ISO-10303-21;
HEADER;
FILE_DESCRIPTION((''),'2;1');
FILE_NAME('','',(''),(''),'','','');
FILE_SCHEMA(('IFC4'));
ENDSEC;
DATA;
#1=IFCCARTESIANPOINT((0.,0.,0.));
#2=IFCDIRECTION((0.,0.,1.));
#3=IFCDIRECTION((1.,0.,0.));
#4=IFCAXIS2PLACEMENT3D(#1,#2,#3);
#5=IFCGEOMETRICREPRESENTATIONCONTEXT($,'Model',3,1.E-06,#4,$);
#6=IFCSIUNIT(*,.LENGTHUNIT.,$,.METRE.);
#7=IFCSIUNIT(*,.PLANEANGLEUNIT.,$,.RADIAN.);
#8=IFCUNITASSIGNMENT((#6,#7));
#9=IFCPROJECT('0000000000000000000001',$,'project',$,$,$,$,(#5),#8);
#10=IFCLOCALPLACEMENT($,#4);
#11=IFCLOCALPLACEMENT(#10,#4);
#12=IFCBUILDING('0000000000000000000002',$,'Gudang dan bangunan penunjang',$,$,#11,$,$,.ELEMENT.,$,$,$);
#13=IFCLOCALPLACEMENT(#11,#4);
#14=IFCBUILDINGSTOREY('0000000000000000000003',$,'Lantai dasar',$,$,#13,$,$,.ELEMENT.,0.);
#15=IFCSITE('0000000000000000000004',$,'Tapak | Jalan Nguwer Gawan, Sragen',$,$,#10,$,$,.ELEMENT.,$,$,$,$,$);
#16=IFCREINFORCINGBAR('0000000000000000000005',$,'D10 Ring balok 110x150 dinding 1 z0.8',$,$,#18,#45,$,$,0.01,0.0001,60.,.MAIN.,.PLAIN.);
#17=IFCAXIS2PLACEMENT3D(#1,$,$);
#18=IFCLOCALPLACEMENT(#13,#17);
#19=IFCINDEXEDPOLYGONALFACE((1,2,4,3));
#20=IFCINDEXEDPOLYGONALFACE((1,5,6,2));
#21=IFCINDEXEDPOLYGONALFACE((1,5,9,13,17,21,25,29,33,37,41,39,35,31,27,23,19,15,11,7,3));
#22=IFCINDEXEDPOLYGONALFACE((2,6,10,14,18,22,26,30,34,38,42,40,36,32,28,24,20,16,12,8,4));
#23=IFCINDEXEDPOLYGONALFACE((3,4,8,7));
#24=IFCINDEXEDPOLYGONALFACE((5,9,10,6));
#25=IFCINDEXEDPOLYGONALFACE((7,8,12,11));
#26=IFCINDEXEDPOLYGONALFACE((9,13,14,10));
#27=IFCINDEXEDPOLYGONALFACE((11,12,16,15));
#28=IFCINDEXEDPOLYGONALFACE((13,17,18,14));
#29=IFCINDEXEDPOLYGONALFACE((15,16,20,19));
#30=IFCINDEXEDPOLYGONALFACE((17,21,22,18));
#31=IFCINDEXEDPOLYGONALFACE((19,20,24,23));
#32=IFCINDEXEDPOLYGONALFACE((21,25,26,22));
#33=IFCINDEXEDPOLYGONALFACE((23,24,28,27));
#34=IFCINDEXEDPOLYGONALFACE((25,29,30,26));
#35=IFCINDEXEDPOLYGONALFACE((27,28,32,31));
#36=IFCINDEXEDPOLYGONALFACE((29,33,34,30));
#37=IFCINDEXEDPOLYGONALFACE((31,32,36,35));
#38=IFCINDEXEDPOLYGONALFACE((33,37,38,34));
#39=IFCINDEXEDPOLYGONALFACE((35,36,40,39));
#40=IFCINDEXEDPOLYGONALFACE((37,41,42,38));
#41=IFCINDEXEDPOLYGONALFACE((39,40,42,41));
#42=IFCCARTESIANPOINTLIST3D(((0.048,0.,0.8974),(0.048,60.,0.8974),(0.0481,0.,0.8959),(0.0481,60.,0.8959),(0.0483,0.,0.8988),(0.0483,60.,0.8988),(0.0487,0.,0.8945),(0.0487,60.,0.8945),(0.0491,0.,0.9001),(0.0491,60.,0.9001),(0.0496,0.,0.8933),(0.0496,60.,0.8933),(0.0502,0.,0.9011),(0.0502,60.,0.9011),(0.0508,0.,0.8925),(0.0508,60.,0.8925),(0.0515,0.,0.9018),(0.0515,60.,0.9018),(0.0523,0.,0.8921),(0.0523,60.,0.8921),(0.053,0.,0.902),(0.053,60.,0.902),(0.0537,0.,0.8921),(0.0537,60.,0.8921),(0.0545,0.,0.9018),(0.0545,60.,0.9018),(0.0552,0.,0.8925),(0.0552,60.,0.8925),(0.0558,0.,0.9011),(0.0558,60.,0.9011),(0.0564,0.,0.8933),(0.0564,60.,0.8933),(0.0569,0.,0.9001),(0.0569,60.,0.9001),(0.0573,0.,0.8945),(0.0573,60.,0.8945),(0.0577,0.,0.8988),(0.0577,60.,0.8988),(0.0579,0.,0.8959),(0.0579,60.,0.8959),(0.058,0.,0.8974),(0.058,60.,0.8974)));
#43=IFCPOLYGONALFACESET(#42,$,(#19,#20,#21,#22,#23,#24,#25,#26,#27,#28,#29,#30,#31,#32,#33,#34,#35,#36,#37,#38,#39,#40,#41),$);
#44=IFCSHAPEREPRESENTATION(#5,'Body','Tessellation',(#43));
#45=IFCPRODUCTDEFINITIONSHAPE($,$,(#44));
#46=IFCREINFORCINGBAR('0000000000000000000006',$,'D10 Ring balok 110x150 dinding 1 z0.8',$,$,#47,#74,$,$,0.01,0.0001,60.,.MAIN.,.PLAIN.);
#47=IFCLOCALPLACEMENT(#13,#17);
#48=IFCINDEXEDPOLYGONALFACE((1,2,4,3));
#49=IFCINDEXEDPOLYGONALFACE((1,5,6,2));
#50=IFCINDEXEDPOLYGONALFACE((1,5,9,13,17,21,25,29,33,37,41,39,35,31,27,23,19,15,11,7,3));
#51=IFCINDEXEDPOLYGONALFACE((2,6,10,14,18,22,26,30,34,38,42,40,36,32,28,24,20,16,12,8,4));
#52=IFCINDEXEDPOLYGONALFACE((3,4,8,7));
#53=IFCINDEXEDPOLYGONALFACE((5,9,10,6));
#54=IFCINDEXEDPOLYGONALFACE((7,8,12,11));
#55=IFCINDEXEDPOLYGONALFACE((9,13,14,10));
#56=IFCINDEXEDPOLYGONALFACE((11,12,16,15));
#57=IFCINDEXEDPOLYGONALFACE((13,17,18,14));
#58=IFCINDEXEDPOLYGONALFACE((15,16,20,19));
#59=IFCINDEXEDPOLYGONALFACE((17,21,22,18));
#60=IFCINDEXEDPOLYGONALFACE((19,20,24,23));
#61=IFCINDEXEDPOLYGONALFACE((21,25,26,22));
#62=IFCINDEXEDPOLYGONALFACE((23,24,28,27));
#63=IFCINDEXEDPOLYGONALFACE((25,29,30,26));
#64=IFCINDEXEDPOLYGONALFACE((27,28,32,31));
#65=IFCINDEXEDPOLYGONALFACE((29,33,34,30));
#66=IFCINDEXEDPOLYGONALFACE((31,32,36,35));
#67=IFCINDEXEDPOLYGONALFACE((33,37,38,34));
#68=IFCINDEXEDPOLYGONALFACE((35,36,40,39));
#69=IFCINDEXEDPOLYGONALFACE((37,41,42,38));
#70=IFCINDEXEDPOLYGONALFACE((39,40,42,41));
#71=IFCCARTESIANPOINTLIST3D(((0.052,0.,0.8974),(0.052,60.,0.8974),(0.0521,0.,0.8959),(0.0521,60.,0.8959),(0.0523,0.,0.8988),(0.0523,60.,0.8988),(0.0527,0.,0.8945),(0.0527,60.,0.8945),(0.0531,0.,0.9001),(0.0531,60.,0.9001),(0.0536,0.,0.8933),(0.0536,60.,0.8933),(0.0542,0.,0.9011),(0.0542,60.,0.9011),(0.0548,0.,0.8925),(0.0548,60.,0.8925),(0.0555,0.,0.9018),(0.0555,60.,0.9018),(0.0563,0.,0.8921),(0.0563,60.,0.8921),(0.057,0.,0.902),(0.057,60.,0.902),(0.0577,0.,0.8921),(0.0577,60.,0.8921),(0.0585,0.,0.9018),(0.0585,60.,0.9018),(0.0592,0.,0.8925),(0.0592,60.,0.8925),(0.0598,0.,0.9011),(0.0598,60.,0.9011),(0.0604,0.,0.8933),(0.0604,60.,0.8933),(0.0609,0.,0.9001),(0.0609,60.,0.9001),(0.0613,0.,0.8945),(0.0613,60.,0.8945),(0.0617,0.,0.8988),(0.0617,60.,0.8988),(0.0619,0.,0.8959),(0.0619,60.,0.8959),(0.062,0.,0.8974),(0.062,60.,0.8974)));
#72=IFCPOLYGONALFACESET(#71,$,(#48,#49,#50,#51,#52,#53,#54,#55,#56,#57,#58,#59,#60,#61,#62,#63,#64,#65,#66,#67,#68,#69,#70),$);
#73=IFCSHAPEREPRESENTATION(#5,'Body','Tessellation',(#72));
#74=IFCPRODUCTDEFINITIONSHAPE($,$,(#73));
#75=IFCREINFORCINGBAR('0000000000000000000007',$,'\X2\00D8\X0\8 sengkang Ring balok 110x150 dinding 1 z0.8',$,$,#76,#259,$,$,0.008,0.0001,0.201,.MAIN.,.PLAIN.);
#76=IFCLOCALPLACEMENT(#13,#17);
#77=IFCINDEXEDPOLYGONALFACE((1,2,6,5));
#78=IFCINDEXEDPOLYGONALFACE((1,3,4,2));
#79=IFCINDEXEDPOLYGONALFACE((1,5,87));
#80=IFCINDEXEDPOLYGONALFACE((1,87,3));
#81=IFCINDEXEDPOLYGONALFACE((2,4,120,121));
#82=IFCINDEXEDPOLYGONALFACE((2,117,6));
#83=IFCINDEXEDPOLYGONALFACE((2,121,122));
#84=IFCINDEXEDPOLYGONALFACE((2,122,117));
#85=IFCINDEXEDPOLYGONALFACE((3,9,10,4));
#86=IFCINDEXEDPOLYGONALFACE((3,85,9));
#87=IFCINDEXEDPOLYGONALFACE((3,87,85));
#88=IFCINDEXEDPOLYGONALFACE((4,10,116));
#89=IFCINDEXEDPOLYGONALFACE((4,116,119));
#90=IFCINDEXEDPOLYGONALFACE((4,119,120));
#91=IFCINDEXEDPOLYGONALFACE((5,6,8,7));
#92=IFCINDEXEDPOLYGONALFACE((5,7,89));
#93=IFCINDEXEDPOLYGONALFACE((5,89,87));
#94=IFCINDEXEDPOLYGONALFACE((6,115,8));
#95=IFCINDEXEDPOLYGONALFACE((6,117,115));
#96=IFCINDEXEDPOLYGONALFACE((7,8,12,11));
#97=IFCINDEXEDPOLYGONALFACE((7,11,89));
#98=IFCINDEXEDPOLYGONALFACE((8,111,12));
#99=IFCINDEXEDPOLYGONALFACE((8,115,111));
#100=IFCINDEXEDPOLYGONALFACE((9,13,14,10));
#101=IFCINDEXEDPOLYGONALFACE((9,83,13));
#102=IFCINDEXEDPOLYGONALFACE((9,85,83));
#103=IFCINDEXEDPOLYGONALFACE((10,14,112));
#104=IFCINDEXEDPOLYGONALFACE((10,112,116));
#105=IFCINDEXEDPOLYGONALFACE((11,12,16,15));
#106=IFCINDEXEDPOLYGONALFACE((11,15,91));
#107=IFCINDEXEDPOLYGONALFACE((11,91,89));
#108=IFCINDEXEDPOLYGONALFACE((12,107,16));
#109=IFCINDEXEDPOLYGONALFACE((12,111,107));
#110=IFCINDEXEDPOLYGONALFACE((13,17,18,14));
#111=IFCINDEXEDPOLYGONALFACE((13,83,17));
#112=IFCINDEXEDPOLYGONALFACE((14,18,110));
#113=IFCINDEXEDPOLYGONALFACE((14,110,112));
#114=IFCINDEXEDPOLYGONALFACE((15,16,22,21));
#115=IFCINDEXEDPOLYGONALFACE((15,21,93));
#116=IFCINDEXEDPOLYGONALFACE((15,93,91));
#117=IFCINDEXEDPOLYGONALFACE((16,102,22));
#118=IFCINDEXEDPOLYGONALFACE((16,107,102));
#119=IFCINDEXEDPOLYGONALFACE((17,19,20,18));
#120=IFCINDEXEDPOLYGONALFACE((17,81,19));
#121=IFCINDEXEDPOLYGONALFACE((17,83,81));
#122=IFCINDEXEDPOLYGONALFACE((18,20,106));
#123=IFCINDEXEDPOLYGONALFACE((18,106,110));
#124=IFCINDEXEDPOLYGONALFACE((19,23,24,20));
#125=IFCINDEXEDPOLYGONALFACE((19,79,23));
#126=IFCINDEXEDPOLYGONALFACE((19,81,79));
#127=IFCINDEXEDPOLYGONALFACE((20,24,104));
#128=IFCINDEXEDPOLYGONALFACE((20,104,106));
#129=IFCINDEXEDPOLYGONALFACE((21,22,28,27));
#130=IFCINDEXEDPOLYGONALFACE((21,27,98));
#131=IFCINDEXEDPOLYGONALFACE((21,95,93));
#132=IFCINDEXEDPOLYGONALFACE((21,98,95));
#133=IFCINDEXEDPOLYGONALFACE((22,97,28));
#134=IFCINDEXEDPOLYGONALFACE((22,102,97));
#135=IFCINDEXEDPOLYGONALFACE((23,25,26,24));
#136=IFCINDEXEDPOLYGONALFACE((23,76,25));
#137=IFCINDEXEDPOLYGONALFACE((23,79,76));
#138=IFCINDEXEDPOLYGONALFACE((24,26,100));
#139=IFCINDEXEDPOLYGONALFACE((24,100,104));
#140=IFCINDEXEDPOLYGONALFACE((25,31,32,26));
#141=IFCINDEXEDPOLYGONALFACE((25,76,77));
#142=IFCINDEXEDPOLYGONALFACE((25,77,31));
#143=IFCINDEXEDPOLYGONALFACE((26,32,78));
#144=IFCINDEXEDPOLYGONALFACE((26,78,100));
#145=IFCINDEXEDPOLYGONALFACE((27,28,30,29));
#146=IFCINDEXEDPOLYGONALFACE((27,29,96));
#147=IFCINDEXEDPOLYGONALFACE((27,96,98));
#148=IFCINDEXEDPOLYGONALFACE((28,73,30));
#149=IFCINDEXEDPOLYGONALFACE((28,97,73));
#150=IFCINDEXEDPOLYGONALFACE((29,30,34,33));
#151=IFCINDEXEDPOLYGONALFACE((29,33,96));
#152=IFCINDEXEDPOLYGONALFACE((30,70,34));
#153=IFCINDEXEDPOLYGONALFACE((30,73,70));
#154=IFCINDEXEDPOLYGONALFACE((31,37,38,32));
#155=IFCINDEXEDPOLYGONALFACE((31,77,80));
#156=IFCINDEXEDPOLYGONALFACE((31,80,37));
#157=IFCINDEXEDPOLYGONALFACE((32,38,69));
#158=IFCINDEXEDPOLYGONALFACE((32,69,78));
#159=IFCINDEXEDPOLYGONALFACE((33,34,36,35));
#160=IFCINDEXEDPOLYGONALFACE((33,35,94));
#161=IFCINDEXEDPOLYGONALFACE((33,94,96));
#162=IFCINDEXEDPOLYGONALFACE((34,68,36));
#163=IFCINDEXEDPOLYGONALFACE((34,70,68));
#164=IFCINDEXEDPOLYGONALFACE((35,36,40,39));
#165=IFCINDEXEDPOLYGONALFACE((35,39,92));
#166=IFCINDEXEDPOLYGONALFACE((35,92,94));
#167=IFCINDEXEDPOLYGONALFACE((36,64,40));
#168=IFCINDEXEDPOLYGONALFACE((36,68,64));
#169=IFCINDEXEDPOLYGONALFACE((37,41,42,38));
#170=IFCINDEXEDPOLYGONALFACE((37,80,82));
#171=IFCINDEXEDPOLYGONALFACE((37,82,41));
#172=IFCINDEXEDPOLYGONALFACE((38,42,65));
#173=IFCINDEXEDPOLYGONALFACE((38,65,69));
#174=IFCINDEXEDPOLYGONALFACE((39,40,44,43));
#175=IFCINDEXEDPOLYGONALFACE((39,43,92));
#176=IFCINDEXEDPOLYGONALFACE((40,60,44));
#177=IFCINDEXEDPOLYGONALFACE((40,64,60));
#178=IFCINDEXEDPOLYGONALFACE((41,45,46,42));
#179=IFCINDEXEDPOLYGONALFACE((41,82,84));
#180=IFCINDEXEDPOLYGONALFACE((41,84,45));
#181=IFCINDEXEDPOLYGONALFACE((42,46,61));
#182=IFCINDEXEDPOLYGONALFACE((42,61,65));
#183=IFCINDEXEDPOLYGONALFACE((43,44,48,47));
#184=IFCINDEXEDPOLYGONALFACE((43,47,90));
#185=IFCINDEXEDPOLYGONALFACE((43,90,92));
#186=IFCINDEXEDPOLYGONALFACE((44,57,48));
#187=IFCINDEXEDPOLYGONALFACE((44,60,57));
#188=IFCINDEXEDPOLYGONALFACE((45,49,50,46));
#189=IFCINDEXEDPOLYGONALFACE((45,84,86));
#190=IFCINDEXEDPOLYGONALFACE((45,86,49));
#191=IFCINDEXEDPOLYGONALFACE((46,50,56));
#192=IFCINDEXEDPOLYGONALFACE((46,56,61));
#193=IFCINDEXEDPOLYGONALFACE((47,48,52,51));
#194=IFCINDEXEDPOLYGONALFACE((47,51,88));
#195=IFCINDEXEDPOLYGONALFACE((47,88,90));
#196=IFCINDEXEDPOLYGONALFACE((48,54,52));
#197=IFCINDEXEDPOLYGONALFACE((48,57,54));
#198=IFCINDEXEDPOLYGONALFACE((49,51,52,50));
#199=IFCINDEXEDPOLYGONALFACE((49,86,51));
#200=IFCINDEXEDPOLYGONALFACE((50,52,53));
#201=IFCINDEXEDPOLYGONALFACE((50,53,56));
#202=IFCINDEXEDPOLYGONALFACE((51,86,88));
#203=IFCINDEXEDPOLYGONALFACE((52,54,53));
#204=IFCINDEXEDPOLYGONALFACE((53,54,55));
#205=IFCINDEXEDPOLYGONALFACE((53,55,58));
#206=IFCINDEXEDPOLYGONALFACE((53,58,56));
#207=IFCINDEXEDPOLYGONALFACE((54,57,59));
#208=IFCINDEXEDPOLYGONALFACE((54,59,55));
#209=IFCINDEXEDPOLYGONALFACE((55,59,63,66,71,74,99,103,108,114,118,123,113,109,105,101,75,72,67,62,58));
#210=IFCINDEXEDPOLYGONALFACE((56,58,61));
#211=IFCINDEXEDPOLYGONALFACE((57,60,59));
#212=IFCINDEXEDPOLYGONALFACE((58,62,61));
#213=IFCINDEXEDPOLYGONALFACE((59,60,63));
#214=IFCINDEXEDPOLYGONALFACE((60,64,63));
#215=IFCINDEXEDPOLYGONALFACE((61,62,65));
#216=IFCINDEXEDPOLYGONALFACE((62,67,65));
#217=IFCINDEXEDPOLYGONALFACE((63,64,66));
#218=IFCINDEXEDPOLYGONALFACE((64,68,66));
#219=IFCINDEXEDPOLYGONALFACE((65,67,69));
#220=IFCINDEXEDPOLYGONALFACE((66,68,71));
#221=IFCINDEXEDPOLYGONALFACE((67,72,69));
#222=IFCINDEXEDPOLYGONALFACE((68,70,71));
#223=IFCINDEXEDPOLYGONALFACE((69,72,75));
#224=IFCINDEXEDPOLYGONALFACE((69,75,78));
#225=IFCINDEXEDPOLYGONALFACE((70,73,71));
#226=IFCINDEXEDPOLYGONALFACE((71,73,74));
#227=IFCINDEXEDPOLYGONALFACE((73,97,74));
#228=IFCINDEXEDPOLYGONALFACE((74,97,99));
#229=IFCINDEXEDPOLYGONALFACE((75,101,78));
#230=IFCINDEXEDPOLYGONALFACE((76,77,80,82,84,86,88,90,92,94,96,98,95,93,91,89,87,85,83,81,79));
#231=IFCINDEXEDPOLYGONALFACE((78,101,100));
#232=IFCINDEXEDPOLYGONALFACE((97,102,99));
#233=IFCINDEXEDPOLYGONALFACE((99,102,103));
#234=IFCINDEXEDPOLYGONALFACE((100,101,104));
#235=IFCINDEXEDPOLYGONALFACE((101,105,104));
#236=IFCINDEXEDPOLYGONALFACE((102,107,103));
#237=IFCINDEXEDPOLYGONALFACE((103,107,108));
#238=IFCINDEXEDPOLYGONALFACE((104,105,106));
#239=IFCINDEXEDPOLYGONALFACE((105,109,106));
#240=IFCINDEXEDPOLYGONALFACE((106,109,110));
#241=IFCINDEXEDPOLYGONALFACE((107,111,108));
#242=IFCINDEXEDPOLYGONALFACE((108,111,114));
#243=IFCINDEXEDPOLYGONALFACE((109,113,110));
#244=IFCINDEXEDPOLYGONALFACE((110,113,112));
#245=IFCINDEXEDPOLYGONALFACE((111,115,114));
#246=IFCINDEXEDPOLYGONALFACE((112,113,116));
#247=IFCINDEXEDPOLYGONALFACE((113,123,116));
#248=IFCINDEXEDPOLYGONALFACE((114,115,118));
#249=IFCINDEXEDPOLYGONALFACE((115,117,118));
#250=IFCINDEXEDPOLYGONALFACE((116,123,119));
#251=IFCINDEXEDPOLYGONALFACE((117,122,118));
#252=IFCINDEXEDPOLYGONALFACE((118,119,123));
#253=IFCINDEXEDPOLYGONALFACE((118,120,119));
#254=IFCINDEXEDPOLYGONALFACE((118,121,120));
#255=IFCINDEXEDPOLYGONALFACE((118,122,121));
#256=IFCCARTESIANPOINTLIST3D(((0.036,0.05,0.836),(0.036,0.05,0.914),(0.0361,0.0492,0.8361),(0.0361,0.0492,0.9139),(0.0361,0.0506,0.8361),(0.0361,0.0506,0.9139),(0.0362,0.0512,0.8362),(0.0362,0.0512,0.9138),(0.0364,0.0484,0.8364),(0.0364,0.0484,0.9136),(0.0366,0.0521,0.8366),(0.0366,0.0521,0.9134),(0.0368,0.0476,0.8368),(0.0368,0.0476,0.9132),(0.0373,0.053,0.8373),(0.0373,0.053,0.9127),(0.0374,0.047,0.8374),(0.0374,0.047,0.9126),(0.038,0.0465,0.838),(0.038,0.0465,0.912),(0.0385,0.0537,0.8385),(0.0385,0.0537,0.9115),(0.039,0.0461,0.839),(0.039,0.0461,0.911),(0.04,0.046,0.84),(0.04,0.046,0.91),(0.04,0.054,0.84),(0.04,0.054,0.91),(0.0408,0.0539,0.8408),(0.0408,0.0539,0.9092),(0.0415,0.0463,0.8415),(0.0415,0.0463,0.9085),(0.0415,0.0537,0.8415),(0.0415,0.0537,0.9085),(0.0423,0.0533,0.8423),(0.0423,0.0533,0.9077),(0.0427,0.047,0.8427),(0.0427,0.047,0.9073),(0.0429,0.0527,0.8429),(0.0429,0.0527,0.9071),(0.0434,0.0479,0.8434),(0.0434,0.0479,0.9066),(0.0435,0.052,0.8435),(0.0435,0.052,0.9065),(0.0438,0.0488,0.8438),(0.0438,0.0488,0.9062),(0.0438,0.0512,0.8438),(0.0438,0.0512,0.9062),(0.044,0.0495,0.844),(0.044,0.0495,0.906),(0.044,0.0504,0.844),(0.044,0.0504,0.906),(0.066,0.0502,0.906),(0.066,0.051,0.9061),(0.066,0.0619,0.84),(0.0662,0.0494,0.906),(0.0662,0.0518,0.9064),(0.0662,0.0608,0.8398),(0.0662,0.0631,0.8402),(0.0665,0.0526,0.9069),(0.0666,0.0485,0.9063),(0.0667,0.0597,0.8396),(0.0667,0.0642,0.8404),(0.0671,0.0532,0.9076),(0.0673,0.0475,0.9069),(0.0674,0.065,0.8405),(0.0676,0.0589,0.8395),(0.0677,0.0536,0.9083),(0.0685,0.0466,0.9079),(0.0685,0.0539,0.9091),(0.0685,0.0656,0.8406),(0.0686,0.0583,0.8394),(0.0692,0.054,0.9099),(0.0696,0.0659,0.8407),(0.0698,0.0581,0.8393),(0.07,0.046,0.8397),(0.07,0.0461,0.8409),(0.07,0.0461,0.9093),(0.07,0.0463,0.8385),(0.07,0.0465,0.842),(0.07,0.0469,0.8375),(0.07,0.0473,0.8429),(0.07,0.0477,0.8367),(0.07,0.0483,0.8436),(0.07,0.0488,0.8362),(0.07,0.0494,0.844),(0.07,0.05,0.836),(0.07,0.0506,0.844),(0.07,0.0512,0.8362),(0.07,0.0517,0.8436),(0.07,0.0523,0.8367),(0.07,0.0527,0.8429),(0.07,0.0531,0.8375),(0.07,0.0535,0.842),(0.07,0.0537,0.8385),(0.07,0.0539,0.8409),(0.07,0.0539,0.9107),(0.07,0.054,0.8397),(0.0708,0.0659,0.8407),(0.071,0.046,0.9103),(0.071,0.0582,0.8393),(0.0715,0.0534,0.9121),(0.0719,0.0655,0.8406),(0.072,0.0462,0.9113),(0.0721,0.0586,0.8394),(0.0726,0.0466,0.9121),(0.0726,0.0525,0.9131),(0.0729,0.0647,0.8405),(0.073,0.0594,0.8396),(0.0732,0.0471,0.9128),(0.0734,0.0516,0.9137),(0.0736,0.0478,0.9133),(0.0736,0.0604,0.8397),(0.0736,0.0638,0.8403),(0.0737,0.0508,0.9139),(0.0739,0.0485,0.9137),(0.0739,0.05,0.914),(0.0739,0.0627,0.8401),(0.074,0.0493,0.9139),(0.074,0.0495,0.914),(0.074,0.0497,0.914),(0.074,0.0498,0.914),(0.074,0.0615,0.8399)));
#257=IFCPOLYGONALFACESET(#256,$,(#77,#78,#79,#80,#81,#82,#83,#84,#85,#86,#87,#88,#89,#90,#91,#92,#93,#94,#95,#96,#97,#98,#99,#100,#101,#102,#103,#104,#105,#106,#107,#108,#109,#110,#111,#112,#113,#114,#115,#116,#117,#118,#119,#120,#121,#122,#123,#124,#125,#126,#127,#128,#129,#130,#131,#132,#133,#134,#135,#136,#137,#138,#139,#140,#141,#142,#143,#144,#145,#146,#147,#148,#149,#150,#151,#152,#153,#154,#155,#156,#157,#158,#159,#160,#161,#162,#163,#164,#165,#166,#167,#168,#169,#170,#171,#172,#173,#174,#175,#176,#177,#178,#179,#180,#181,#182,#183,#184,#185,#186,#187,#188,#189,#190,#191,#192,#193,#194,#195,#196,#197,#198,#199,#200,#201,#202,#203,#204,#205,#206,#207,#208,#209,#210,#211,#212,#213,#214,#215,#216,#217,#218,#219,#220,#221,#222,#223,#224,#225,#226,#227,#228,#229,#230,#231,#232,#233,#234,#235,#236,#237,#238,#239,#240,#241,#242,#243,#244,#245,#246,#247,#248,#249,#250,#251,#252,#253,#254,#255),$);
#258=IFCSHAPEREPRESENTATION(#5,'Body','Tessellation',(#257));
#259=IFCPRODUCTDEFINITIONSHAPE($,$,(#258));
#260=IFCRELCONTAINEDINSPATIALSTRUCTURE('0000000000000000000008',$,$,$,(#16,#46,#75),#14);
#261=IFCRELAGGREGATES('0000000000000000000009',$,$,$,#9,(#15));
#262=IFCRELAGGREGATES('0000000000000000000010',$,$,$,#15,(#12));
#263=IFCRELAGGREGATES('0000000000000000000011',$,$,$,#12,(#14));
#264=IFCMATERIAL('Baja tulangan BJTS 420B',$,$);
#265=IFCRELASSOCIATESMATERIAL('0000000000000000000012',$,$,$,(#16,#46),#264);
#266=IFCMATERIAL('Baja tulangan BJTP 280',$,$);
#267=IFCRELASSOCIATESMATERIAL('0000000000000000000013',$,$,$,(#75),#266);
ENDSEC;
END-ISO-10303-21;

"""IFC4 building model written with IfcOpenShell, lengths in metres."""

from ifc_helpers import new_model, entity, si_unit, origin_with_axes, place, context, project, spatial, material, element, save


model = new_model("IFC4")

# Units and contexts
model_context = context("Model", 3, precision=1e-06, world=origin_with_axes())
ifc_project = project(units=[si_unit("LENGTHUNIT", "METRE"), si_unit("PLANEANGLEUNIT", "RADIAN")], contexts=[model_context])

# Site, building, storey
site_placement = place(None, origin_with_axes())
site = spatial("IfcSite", under=ifc_project, at=site_placement, Name="Tapak | Jalan Nguwer Gawan, Sragen", CompositionType="ELEMENT")
building_placement = place(site_placement, origin_with_axes())
building = spatial("IfcBuilding", under=site, at=building_placement, Name="Gudang dan bangunan penunjang", CompositionType="ELEMENT")
storey_placement = place(building_placement, origin_with_axes())
storey = spatial("IfcBuildingStorey", under=building, at=storey_placement, Name="Lantai dasar", CompositionType="ELEMENT", Elevation=0.0)

# Shared definitions
placement = place(None, origin_with_axes())

# Reinforcing bars
ifc_material_1 = material(Name="Baja tulangan BJTP 280")
ifc_material_2 = material(Name="Baja tulangan BJTS 420B")
element("IfcReinforcingBar", 1, at=placement, inside=storey, material=ifc_material_2, Name="D10 Ring balok 110x150 dinding 1 z0.8", BarLength=60.0, BarSurface="PLAIN", CrossSectionArea=0.0001, NominalDiameter=0.01, PredefinedType="MAIN", context=model_context, shape_type="AdvancedSweptSolid", body=[
    entity("IfcSweptDiskSolid", entity("IfcPolyline", [entity("IfcCartesianPoint", [0.053, 0.0, 0.897]), entity("IfcCartesianPoint", [0.053, 60.0, 0.897])]), 0.005),
])
element("IfcReinforcingBar", 2, at=placement, inside=storey, material=ifc_material_2, Name="D10 Ring balok 110x150 dinding 1 z0.8", BarLength=60.0, BarSurface="PLAIN", CrossSectionArea=0.0001, NominalDiameter=0.01, PredefinedType="MAIN", context=model_context, shape_type="AdvancedSweptSolid", body=[
    entity("IfcSweptDiskSolid", entity("IfcPolyline", [entity("IfcCartesianPoint", [0.057, 0.0, 0.897]), entity("IfcCartesianPoint", [0.057, 60.0, 0.897])]), 0.005),
])
element("IfcReinforcingBar", 3, at=placement, inside=storey, material=ifc_material_1, Name="Ø8 sengkang Ring balok 110x150 dinding 1 z0.8", BarLength=0.201, BarSurface="PLAIN", CrossSectionArea=0.0001, NominalDiameter=0.008, PredefinedType="MAIN", context=model_context, shape_type="AdvancedSweptSolid", body=[
    entity("IfcSweptDiskSolid", entity("IfcPolyline", [entity("IfcCartesianPoint", [0.07, 0.05, 0.84]), entity("IfcCartesianPoint", [0.04, 0.05, 0.84]), entity("IfcCartesianPoint", [0.04, 0.05, 0.91]), entity("IfcCartesianPoint", [0.07, 0.05, 0.91]), entity("IfcCartesianPoint", [0.07, 0.062, 0.84])]), 0.004),
])

save(model, "model.ifc")
